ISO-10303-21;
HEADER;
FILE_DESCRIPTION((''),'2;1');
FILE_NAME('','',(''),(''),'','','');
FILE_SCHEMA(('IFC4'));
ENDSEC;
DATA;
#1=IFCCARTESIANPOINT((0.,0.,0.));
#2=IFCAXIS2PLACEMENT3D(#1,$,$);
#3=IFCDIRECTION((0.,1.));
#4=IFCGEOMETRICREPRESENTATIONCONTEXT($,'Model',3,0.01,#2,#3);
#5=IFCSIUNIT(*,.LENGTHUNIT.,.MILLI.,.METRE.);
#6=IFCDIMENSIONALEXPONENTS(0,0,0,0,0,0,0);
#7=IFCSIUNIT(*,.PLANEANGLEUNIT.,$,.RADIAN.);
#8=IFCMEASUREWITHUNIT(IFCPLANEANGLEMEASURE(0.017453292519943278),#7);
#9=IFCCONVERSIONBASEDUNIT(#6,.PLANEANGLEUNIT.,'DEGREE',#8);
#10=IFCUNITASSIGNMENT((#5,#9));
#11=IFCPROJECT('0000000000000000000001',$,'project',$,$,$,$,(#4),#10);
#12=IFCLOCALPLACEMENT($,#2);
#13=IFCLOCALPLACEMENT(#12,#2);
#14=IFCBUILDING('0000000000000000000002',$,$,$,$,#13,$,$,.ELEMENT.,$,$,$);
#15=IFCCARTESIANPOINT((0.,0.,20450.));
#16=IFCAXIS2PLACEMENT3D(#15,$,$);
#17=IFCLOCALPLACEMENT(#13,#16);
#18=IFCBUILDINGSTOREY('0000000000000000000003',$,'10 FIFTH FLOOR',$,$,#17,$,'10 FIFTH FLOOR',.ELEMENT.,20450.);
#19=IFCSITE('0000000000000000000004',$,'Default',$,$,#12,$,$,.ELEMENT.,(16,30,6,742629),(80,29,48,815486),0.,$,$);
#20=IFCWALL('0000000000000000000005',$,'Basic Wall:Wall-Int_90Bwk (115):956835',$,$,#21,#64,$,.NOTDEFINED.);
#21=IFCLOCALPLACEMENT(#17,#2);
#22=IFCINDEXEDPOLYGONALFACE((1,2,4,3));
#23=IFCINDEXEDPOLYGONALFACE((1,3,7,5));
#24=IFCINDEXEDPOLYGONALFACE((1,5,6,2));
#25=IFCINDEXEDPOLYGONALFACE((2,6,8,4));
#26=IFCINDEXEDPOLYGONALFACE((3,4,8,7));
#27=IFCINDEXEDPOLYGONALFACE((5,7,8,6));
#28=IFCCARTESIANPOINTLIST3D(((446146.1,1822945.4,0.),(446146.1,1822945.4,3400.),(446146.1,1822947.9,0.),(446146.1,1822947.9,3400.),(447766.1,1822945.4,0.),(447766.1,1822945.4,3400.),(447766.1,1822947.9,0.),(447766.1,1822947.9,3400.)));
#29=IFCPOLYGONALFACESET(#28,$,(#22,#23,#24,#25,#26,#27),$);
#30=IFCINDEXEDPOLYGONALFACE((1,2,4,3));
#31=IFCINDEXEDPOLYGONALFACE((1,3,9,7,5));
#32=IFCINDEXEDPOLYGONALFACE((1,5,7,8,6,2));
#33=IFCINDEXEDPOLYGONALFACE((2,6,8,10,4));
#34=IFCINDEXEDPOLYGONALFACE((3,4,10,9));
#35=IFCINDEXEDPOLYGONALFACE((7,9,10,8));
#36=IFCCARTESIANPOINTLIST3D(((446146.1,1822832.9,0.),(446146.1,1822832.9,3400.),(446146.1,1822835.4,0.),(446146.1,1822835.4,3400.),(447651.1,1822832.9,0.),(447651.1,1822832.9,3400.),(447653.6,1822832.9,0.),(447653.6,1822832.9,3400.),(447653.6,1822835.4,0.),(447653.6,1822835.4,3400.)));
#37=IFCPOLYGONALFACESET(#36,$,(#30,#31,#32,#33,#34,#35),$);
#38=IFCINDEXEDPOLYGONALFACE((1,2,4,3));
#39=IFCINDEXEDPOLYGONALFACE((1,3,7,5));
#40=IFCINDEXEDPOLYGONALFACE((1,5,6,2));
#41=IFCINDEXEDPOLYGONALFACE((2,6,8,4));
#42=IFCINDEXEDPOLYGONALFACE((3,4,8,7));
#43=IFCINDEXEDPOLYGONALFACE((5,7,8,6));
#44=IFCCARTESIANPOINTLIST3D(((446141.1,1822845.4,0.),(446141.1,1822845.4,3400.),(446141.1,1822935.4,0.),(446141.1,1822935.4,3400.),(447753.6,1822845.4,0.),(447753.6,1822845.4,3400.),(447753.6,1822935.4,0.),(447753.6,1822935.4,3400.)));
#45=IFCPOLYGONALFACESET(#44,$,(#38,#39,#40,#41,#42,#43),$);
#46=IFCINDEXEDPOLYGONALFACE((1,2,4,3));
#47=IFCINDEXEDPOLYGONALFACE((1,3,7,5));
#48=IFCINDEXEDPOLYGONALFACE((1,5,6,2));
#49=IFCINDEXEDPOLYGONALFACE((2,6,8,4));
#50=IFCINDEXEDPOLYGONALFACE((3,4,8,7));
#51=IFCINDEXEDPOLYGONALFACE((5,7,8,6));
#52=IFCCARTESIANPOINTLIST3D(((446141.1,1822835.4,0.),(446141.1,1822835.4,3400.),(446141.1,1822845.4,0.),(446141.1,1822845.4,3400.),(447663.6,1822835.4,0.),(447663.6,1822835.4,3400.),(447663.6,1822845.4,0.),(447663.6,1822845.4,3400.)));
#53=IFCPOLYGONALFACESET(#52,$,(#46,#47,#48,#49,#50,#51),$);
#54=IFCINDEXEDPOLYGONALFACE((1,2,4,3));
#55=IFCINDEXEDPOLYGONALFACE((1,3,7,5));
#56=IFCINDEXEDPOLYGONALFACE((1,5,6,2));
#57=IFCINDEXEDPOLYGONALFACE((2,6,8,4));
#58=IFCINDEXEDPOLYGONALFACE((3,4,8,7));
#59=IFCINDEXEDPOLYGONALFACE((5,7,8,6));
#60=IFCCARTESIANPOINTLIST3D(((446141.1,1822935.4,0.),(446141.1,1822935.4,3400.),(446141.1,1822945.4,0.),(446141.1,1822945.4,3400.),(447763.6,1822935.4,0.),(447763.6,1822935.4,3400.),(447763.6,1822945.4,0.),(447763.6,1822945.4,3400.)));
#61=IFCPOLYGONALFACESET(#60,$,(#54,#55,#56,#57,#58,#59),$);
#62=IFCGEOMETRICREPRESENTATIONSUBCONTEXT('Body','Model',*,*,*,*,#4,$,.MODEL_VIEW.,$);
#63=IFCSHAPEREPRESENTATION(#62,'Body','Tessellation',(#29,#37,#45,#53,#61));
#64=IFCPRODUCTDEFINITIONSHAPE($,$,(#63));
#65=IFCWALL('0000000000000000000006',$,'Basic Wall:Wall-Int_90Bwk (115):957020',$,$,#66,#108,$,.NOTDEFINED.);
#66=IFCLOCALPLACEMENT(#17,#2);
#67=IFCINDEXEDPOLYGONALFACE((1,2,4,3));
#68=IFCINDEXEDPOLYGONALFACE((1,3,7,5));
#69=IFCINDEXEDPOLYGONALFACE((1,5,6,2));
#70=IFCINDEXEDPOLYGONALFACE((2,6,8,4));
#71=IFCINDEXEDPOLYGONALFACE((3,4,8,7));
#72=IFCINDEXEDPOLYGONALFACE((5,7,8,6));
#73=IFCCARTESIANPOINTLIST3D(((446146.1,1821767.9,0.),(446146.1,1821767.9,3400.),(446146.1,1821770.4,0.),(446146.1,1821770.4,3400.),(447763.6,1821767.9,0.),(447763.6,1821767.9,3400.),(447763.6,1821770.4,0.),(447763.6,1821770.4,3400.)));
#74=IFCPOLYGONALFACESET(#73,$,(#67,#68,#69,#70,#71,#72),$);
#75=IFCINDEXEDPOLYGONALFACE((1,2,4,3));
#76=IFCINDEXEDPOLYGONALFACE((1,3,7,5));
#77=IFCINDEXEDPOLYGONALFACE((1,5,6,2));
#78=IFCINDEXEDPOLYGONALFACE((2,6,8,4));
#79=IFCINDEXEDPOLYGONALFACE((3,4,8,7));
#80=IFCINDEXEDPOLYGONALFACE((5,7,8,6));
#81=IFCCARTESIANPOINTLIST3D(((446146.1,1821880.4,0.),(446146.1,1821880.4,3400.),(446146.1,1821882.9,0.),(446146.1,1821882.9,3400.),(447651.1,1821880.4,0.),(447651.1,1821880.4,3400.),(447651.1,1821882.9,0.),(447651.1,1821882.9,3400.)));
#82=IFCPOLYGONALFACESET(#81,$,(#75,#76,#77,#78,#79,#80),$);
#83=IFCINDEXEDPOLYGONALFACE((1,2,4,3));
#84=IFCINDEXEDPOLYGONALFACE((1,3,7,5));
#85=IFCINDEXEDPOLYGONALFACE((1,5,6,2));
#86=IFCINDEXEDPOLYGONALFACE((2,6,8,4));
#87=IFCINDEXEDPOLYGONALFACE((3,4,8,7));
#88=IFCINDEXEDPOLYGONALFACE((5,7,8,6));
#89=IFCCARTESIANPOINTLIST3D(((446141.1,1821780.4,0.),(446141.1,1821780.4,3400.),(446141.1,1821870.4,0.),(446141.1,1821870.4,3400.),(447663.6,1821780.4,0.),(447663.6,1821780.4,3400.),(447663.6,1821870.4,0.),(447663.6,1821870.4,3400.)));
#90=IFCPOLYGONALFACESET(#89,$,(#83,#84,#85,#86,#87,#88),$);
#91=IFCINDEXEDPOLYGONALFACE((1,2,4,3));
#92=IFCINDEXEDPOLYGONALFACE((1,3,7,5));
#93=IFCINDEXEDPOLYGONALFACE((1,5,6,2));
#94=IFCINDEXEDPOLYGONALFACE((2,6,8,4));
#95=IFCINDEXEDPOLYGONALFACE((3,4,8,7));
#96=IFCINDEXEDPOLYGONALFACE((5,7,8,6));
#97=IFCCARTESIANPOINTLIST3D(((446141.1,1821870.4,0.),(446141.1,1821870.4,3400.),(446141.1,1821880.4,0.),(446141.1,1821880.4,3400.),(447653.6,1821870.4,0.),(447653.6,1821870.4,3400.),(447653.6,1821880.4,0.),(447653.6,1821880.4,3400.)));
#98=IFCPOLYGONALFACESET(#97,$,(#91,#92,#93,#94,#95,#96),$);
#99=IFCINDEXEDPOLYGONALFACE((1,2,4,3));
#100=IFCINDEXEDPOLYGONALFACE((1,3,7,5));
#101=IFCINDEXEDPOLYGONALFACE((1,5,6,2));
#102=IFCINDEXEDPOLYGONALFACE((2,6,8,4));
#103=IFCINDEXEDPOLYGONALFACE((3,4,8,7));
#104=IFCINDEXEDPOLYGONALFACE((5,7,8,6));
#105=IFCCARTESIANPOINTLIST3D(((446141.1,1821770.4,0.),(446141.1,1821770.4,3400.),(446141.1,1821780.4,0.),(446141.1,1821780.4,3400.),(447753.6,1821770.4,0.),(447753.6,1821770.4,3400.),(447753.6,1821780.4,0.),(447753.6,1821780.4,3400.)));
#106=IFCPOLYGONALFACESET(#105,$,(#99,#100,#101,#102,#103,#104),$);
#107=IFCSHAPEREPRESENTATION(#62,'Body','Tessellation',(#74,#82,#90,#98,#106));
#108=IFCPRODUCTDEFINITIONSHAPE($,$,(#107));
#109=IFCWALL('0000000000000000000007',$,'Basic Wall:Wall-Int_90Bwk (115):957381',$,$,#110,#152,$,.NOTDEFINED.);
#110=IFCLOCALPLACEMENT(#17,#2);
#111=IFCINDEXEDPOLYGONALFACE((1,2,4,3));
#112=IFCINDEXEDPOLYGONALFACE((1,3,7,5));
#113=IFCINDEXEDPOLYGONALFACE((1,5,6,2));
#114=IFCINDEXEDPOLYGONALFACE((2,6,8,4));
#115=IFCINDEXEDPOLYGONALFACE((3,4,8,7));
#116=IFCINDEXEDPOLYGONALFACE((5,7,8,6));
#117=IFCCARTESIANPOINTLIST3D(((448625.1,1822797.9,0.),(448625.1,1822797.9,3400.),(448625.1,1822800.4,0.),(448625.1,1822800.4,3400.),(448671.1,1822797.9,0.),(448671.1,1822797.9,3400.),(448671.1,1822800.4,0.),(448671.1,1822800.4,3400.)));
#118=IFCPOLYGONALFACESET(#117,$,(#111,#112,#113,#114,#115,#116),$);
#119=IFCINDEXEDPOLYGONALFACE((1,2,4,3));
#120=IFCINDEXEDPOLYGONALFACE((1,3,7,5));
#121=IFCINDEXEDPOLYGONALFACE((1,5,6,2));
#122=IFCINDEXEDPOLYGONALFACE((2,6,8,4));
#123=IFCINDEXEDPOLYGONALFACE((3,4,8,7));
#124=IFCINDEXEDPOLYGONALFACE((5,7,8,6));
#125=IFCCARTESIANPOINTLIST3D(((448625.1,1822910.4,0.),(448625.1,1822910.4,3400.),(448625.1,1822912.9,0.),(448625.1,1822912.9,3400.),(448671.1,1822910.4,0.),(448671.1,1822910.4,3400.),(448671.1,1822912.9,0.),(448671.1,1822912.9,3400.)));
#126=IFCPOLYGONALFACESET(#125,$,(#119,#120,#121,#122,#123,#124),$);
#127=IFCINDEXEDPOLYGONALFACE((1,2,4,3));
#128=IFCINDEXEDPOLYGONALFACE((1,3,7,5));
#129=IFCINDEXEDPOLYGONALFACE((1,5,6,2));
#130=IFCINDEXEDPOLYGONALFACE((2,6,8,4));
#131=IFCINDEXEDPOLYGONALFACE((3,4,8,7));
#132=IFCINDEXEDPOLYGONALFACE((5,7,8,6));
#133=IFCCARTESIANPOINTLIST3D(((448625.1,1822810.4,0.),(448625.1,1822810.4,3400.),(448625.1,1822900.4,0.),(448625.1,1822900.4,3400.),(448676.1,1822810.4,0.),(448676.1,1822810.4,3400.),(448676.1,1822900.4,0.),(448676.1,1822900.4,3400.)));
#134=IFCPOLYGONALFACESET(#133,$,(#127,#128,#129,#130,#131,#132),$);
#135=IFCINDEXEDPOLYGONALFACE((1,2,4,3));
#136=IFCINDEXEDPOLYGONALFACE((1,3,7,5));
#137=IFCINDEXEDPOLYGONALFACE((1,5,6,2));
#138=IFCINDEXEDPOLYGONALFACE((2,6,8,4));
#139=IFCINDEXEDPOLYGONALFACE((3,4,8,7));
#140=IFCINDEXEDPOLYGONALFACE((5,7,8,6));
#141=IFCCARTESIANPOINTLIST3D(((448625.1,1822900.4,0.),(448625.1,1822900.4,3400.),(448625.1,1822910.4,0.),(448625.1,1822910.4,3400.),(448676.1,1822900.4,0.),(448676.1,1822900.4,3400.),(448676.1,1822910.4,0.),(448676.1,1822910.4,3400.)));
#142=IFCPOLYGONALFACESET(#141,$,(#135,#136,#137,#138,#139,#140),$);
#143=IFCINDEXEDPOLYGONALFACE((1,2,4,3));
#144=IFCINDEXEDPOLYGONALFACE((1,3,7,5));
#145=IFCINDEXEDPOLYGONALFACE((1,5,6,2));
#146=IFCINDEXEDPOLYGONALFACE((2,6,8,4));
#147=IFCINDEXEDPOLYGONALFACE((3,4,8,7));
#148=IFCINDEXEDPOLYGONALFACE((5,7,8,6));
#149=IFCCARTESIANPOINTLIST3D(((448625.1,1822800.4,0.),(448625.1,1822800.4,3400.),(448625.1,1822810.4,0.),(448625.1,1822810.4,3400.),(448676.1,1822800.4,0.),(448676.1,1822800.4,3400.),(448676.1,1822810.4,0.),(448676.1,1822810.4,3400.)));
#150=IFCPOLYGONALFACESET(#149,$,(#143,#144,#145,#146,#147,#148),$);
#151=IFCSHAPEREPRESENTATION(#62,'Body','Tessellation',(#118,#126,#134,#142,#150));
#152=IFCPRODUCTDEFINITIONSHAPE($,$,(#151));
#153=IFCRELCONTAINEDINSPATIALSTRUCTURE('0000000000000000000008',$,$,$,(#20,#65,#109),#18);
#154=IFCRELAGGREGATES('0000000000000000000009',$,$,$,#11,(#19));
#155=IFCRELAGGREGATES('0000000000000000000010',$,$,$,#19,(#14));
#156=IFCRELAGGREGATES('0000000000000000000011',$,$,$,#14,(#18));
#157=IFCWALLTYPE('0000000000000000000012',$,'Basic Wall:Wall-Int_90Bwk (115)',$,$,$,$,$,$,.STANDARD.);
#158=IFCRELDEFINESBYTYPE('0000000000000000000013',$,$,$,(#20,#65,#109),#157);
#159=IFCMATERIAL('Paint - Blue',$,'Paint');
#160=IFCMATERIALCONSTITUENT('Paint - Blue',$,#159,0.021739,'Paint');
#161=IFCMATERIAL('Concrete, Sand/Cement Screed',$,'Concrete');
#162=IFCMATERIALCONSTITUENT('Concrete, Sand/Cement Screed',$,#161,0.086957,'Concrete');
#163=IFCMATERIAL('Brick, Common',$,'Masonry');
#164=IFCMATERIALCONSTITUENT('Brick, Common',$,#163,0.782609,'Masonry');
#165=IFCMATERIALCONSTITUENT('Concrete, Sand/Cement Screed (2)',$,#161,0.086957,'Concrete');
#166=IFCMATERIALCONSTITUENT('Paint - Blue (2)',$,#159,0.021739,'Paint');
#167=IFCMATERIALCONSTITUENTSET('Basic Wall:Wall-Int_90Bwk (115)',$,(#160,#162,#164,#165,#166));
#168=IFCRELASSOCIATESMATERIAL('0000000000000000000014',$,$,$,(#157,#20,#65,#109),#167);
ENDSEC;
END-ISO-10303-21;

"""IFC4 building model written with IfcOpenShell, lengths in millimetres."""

from ifc_helpers import new_model, entity, si_unit, converted_unit, direction, frame, origin, place, context, subcontext, project, spatial, indexed_curve, outline, extrude, material, constituent, constituent_set, type_object, element, save


model = new_model("IFC4")

# Units and contexts
model_context = context("Model", 3, precision=0.01, world=origin(), true_north=direction((0.0, 1.0)))
body_context = subcontext(model_context, "Body", "Model", "MODEL_VIEW")
ifc_project = project(units=[si_unit("LENGTHUNIT", "METRE", prefix="MILLI"), converted_unit("PLANEANGLEUNIT", "DEGREE", entity("IfcPlaneAngleMeasure", 0.017453292519943278), si_unit("PLANEANGLEUNIT", "RADIAN"), dimensions=[0, 0, 0, 0, 0, 0, 0])], contexts=[model_context])

# Site, building, storey
site_placement = place(None, origin())
site = spatial("IfcSite", under=ifc_project, at=site_placement, Name="Default", CompositionType="ELEMENT", RefLatitude=(16, 30, 6, 742629), RefLongitude=(80, 29, 48, 815486), RefElevation=0.0)
building_placement = place(site_placement, origin())
building = spatial("IfcBuilding", under=site, at=building_placement, CompositionType="ELEMENT")
storey_placement = place(building_placement, frame((0.0, 0.0, 20450.0)))
storey = spatial("IfcBuildingStorey", under=building, at=storey_placement, Name="10 FIFTH FLOOR", LongName="10 FIFTH FLOOR", CompositionType="ELEMENT", Elevation=20450.0)

# Shared definitions
ifc_material_1 = material(Name="Paint - Blue", Category="Paint")
ifc_constituent_1 = constituent(ifc_material_1, Name="Paint - Blue", Category="Paint", fraction=0.021739)
ifc_material_2 = material(Name="Concrete, Sand/Cement Screed", Category="Concrete")
ifc_constituent_2 = constituent(ifc_material_2, Name="Concrete, Sand/Cement Screed", Category="Concrete", fraction=0.086957)
ifc_material_3 = material(Name="Brick, Common", Category="Masonry")
ifc_constituent_3 = constituent(ifc_material_3, Name="Brick, Common", Category="Masonry", fraction=0.782609)
ifc_constituent_4 = constituent(ifc_material_2, Name="Concrete, Sand/Cement Screed (2)", Category="Concrete", fraction=0.086957)
ifc_constituent_5 = constituent(ifc_material_1, Name="Paint - Blue (2)", Category="Paint", fraction=0.021739)
ifc_constituent_set_1 = constituent_set(constituents=[ifc_constituent_1, ifc_constituent_2, ifc_constituent_3, ifc_constituent_4, ifc_constituent_5], Name="Basic Wall:Wall-Int_90Bwk (115)")
wall_type_1 = type_object("IfcWallType", Name="Basic Wall:Wall-Int_90Bwk (115)", PredefinedType="STANDARD", material=ifc_constituent_set_1)

# Walls
wall_1_placement = place(storey_placement, frame((446146.1, 1822890.4, 0.0)))
element("IfcWall", 1, at=wall_1_placement, inside=storey, type_object=wall_type_1, material=ifc_constituent_set_1, Name="Basic Wall:Wall-Int_90Bwk (115):956835", PredefinedType="NOTDEFINED", context=body_context, shape_type="SweptSolid", body=[
    extrude(outline(indexed_curve([(-1.3, -810.0), (1.3, -810.0), (1.3, 810.0), (-1.3, 810.0), (-1.3, -810.0)], self_intersect=False)), frame((810.0, 56.3, 0.0), z_axis=(0.0, 0.0, 1.0), x_axis=(0.0, -1.0, 0.0)), (0.0, 0.0, 1.0), 3400.0),
    extrude(outline(indexed_curve([(601.0, -1.0), (603.5, -1.0), (603.5, 1.5), (-904.0, 1.5), (-904.0, -1.0), (601.0, -1.0)], self_intersect=False)), frame((904.0, -56.5, 0.0)), (0.0, 0.0, 1.0), 3400.0),
    extrude(outline(indexed_curve([(-806.3, -45.0), (806.3, -45.0), (806.3, 45.0), (-806.3, 45.0), (-806.3, -45.0)], self_intersect=False)), frame((801.3, 0.0, 0.0)), (0.0, 0.0, 1.0), 3400.0),
    extrude(outline(indexed_curve([(-761.3, -5.0), (761.3, -5.0), (761.3, 5.0), (-761.3, 5.0), (-761.3, -5.0)], self_intersect=False)), frame((756.3, -50.0, 0.0)), (0.0, 0.0, 1.0), 3400.0),
    extrude(outline(indexed_curve([(-811.3, -5.0), (811.2, -5.0), (811.2, 5.0), (-811.3, 5.0), (-811.3, -5.0)], self_intersect=False)), frame((806.3, 50.0, 0.0)), (0.0, 0.0, 1.0), 3400.0),
])
wall_2_placement = place(storey_placement, frame((447651.1, 1821825.4, 0.0), z_axis=(0.0, 0.0, 1.0), x_axis=(-1.0, 0.0, 0.0)))
element("IfcWall", 2, at=wall_2_placement, inside=storey, type_object=wall_type_1, material=ifc_constituent_set_1, Name="Basic Wall:Wall-Int_90Bwk (115):957020", PredefinedType="NOTDEFINED", context=body_context, shape_type="SweptSolid", body=[
    extrude(outline(indexed_curve([(-1.3, -808.8), (1.3, -808.8), (1.3, 808.8), (-1.3, 808.8), (-1.3, -808.8)], self_intersect=False)), frame((696.3, 56.3, 0.0), z_axis=(0.0, 0.0, 1.0), x_axis=(0.0, -1.0, 0.0)), (0.0, 0.0, 1.0), 3400.0),
    extrude(outline(indexed_curve([(-1.2, -752.5), (1.3, -752.5), (1.3, 752.5), (-1.2, 752.5), (-1.2, -752.5)], self_intersect=False)), frame((752.5, -56.3, 0.0), z_axis=(0.0, 0.0, 1.0), x_axis=(0.0, 1.0, 0.0)), (0.0, 0.0, 1.0), 3400.0),
    extrude(outline(indexed_curve([(-761.3, -45.0), (761.3, -45.0), (761.3, 45.0), (-761.3, 45.0), (-761.3, -45.0)], self_intersect=False)), frame((748.8, 0.0, 0.0)), (0.0, 0.0, 1.0), 3400.0),
    extrude(outline(indexed_curve([(-756.2, -5.0), (756.3, -5.0), (756.3, 5.0), (-756.2, 5.0), (-756.2, -5.0)], self_intersect=False)), frame((753.7, -50.0, 0.0)), (0.0, 0.0, 1.0), 3400.0),
    extrude(outline(indexed_curve([(-806.2, -5.0), (806.3, -5.0), (806.3, 5.0), (-806.2, 5.0), (-806.2, -5.0)], self_intersect=False)), frame((703.7, 50.0, 0.0)), (0.0, 0.0, 1.0), 3400.0),
])

# Wall
wall_3_placement = place(storey_placement, frame((448671.1, 1822855.4, 0.0), z_axis=(0.0, 0.0, 1.0), x_axis=(-1.0, 0.0, 0.0)))
element("IfcWall", 3, at=wall_3_placement, inside=storey, type_object=wall_type_1, material=ifc_constituent_set_1, Name="Basic Wall:Wall-Int_90Bwk (115):957381", PredefinedType="NOTDEFINED", context=body_context, shape_type="SweptSolid", body=[
    extrude(outline(indexed_curve([(-1.3, -23.0), (1.3, -23.0), (1.3, 23.0), (-1.3, 23.0), (-1.3, -23.0)], self_intersect=False)), frame((23.0, 56.3, 0.0), z_axis=(0.0, 0.0, 1.0), x_axis=(0.0, -1.0, 0.0)), (0.0, 0.0, 1.0), 3400.0),
    extrude(outline(indexed_curve([(-1.3, -23.0), (1.2, -23.0), (1.2, 23.0), (-1.3, 23.0), (-1.3, -23.0)], self_intersect=False)), frame((23.0, -56.2, 0.0), z_axis=(0.0, 0.0, 1.0), x_axis=(0.0, 1.0, 0.0)), (0.0, 0.0, 1.0), 3400.0),
    extrude(outline(indexed_curve([(-25.5, -45.0), (25.5, -45.0), (25.5, 45.0), (-25.5, 45.0), (-25.5, -45.0)], self_intersect=False)), frame((20.5, 0.0, 0.0)), (0.0, 0.0, 1.0), 3400.0),
    extrude(outline(indexed_curve([(-25.5, -5.0), (25.5, -5.0), (25.5, 5.0), (-25.5, 5.0), (-25.5, -5.0)], self_intersect=False)), frame((20.5, -50.0, 0.0)), (0.0, 0.0, 1.0), 3400.0),
    extrude(outline(indexed_curve([(-25.5, -5.0), (25.5, -5.0), (25.5, 5.0), (-25.5, 5.0), (-25.5, -5.0)], self_intersect=False)), frame((20.5, 50.0, 0.0)), (0.0, 0.0, 1.0), 3400.0),
])

save(model, "model.ifc")
